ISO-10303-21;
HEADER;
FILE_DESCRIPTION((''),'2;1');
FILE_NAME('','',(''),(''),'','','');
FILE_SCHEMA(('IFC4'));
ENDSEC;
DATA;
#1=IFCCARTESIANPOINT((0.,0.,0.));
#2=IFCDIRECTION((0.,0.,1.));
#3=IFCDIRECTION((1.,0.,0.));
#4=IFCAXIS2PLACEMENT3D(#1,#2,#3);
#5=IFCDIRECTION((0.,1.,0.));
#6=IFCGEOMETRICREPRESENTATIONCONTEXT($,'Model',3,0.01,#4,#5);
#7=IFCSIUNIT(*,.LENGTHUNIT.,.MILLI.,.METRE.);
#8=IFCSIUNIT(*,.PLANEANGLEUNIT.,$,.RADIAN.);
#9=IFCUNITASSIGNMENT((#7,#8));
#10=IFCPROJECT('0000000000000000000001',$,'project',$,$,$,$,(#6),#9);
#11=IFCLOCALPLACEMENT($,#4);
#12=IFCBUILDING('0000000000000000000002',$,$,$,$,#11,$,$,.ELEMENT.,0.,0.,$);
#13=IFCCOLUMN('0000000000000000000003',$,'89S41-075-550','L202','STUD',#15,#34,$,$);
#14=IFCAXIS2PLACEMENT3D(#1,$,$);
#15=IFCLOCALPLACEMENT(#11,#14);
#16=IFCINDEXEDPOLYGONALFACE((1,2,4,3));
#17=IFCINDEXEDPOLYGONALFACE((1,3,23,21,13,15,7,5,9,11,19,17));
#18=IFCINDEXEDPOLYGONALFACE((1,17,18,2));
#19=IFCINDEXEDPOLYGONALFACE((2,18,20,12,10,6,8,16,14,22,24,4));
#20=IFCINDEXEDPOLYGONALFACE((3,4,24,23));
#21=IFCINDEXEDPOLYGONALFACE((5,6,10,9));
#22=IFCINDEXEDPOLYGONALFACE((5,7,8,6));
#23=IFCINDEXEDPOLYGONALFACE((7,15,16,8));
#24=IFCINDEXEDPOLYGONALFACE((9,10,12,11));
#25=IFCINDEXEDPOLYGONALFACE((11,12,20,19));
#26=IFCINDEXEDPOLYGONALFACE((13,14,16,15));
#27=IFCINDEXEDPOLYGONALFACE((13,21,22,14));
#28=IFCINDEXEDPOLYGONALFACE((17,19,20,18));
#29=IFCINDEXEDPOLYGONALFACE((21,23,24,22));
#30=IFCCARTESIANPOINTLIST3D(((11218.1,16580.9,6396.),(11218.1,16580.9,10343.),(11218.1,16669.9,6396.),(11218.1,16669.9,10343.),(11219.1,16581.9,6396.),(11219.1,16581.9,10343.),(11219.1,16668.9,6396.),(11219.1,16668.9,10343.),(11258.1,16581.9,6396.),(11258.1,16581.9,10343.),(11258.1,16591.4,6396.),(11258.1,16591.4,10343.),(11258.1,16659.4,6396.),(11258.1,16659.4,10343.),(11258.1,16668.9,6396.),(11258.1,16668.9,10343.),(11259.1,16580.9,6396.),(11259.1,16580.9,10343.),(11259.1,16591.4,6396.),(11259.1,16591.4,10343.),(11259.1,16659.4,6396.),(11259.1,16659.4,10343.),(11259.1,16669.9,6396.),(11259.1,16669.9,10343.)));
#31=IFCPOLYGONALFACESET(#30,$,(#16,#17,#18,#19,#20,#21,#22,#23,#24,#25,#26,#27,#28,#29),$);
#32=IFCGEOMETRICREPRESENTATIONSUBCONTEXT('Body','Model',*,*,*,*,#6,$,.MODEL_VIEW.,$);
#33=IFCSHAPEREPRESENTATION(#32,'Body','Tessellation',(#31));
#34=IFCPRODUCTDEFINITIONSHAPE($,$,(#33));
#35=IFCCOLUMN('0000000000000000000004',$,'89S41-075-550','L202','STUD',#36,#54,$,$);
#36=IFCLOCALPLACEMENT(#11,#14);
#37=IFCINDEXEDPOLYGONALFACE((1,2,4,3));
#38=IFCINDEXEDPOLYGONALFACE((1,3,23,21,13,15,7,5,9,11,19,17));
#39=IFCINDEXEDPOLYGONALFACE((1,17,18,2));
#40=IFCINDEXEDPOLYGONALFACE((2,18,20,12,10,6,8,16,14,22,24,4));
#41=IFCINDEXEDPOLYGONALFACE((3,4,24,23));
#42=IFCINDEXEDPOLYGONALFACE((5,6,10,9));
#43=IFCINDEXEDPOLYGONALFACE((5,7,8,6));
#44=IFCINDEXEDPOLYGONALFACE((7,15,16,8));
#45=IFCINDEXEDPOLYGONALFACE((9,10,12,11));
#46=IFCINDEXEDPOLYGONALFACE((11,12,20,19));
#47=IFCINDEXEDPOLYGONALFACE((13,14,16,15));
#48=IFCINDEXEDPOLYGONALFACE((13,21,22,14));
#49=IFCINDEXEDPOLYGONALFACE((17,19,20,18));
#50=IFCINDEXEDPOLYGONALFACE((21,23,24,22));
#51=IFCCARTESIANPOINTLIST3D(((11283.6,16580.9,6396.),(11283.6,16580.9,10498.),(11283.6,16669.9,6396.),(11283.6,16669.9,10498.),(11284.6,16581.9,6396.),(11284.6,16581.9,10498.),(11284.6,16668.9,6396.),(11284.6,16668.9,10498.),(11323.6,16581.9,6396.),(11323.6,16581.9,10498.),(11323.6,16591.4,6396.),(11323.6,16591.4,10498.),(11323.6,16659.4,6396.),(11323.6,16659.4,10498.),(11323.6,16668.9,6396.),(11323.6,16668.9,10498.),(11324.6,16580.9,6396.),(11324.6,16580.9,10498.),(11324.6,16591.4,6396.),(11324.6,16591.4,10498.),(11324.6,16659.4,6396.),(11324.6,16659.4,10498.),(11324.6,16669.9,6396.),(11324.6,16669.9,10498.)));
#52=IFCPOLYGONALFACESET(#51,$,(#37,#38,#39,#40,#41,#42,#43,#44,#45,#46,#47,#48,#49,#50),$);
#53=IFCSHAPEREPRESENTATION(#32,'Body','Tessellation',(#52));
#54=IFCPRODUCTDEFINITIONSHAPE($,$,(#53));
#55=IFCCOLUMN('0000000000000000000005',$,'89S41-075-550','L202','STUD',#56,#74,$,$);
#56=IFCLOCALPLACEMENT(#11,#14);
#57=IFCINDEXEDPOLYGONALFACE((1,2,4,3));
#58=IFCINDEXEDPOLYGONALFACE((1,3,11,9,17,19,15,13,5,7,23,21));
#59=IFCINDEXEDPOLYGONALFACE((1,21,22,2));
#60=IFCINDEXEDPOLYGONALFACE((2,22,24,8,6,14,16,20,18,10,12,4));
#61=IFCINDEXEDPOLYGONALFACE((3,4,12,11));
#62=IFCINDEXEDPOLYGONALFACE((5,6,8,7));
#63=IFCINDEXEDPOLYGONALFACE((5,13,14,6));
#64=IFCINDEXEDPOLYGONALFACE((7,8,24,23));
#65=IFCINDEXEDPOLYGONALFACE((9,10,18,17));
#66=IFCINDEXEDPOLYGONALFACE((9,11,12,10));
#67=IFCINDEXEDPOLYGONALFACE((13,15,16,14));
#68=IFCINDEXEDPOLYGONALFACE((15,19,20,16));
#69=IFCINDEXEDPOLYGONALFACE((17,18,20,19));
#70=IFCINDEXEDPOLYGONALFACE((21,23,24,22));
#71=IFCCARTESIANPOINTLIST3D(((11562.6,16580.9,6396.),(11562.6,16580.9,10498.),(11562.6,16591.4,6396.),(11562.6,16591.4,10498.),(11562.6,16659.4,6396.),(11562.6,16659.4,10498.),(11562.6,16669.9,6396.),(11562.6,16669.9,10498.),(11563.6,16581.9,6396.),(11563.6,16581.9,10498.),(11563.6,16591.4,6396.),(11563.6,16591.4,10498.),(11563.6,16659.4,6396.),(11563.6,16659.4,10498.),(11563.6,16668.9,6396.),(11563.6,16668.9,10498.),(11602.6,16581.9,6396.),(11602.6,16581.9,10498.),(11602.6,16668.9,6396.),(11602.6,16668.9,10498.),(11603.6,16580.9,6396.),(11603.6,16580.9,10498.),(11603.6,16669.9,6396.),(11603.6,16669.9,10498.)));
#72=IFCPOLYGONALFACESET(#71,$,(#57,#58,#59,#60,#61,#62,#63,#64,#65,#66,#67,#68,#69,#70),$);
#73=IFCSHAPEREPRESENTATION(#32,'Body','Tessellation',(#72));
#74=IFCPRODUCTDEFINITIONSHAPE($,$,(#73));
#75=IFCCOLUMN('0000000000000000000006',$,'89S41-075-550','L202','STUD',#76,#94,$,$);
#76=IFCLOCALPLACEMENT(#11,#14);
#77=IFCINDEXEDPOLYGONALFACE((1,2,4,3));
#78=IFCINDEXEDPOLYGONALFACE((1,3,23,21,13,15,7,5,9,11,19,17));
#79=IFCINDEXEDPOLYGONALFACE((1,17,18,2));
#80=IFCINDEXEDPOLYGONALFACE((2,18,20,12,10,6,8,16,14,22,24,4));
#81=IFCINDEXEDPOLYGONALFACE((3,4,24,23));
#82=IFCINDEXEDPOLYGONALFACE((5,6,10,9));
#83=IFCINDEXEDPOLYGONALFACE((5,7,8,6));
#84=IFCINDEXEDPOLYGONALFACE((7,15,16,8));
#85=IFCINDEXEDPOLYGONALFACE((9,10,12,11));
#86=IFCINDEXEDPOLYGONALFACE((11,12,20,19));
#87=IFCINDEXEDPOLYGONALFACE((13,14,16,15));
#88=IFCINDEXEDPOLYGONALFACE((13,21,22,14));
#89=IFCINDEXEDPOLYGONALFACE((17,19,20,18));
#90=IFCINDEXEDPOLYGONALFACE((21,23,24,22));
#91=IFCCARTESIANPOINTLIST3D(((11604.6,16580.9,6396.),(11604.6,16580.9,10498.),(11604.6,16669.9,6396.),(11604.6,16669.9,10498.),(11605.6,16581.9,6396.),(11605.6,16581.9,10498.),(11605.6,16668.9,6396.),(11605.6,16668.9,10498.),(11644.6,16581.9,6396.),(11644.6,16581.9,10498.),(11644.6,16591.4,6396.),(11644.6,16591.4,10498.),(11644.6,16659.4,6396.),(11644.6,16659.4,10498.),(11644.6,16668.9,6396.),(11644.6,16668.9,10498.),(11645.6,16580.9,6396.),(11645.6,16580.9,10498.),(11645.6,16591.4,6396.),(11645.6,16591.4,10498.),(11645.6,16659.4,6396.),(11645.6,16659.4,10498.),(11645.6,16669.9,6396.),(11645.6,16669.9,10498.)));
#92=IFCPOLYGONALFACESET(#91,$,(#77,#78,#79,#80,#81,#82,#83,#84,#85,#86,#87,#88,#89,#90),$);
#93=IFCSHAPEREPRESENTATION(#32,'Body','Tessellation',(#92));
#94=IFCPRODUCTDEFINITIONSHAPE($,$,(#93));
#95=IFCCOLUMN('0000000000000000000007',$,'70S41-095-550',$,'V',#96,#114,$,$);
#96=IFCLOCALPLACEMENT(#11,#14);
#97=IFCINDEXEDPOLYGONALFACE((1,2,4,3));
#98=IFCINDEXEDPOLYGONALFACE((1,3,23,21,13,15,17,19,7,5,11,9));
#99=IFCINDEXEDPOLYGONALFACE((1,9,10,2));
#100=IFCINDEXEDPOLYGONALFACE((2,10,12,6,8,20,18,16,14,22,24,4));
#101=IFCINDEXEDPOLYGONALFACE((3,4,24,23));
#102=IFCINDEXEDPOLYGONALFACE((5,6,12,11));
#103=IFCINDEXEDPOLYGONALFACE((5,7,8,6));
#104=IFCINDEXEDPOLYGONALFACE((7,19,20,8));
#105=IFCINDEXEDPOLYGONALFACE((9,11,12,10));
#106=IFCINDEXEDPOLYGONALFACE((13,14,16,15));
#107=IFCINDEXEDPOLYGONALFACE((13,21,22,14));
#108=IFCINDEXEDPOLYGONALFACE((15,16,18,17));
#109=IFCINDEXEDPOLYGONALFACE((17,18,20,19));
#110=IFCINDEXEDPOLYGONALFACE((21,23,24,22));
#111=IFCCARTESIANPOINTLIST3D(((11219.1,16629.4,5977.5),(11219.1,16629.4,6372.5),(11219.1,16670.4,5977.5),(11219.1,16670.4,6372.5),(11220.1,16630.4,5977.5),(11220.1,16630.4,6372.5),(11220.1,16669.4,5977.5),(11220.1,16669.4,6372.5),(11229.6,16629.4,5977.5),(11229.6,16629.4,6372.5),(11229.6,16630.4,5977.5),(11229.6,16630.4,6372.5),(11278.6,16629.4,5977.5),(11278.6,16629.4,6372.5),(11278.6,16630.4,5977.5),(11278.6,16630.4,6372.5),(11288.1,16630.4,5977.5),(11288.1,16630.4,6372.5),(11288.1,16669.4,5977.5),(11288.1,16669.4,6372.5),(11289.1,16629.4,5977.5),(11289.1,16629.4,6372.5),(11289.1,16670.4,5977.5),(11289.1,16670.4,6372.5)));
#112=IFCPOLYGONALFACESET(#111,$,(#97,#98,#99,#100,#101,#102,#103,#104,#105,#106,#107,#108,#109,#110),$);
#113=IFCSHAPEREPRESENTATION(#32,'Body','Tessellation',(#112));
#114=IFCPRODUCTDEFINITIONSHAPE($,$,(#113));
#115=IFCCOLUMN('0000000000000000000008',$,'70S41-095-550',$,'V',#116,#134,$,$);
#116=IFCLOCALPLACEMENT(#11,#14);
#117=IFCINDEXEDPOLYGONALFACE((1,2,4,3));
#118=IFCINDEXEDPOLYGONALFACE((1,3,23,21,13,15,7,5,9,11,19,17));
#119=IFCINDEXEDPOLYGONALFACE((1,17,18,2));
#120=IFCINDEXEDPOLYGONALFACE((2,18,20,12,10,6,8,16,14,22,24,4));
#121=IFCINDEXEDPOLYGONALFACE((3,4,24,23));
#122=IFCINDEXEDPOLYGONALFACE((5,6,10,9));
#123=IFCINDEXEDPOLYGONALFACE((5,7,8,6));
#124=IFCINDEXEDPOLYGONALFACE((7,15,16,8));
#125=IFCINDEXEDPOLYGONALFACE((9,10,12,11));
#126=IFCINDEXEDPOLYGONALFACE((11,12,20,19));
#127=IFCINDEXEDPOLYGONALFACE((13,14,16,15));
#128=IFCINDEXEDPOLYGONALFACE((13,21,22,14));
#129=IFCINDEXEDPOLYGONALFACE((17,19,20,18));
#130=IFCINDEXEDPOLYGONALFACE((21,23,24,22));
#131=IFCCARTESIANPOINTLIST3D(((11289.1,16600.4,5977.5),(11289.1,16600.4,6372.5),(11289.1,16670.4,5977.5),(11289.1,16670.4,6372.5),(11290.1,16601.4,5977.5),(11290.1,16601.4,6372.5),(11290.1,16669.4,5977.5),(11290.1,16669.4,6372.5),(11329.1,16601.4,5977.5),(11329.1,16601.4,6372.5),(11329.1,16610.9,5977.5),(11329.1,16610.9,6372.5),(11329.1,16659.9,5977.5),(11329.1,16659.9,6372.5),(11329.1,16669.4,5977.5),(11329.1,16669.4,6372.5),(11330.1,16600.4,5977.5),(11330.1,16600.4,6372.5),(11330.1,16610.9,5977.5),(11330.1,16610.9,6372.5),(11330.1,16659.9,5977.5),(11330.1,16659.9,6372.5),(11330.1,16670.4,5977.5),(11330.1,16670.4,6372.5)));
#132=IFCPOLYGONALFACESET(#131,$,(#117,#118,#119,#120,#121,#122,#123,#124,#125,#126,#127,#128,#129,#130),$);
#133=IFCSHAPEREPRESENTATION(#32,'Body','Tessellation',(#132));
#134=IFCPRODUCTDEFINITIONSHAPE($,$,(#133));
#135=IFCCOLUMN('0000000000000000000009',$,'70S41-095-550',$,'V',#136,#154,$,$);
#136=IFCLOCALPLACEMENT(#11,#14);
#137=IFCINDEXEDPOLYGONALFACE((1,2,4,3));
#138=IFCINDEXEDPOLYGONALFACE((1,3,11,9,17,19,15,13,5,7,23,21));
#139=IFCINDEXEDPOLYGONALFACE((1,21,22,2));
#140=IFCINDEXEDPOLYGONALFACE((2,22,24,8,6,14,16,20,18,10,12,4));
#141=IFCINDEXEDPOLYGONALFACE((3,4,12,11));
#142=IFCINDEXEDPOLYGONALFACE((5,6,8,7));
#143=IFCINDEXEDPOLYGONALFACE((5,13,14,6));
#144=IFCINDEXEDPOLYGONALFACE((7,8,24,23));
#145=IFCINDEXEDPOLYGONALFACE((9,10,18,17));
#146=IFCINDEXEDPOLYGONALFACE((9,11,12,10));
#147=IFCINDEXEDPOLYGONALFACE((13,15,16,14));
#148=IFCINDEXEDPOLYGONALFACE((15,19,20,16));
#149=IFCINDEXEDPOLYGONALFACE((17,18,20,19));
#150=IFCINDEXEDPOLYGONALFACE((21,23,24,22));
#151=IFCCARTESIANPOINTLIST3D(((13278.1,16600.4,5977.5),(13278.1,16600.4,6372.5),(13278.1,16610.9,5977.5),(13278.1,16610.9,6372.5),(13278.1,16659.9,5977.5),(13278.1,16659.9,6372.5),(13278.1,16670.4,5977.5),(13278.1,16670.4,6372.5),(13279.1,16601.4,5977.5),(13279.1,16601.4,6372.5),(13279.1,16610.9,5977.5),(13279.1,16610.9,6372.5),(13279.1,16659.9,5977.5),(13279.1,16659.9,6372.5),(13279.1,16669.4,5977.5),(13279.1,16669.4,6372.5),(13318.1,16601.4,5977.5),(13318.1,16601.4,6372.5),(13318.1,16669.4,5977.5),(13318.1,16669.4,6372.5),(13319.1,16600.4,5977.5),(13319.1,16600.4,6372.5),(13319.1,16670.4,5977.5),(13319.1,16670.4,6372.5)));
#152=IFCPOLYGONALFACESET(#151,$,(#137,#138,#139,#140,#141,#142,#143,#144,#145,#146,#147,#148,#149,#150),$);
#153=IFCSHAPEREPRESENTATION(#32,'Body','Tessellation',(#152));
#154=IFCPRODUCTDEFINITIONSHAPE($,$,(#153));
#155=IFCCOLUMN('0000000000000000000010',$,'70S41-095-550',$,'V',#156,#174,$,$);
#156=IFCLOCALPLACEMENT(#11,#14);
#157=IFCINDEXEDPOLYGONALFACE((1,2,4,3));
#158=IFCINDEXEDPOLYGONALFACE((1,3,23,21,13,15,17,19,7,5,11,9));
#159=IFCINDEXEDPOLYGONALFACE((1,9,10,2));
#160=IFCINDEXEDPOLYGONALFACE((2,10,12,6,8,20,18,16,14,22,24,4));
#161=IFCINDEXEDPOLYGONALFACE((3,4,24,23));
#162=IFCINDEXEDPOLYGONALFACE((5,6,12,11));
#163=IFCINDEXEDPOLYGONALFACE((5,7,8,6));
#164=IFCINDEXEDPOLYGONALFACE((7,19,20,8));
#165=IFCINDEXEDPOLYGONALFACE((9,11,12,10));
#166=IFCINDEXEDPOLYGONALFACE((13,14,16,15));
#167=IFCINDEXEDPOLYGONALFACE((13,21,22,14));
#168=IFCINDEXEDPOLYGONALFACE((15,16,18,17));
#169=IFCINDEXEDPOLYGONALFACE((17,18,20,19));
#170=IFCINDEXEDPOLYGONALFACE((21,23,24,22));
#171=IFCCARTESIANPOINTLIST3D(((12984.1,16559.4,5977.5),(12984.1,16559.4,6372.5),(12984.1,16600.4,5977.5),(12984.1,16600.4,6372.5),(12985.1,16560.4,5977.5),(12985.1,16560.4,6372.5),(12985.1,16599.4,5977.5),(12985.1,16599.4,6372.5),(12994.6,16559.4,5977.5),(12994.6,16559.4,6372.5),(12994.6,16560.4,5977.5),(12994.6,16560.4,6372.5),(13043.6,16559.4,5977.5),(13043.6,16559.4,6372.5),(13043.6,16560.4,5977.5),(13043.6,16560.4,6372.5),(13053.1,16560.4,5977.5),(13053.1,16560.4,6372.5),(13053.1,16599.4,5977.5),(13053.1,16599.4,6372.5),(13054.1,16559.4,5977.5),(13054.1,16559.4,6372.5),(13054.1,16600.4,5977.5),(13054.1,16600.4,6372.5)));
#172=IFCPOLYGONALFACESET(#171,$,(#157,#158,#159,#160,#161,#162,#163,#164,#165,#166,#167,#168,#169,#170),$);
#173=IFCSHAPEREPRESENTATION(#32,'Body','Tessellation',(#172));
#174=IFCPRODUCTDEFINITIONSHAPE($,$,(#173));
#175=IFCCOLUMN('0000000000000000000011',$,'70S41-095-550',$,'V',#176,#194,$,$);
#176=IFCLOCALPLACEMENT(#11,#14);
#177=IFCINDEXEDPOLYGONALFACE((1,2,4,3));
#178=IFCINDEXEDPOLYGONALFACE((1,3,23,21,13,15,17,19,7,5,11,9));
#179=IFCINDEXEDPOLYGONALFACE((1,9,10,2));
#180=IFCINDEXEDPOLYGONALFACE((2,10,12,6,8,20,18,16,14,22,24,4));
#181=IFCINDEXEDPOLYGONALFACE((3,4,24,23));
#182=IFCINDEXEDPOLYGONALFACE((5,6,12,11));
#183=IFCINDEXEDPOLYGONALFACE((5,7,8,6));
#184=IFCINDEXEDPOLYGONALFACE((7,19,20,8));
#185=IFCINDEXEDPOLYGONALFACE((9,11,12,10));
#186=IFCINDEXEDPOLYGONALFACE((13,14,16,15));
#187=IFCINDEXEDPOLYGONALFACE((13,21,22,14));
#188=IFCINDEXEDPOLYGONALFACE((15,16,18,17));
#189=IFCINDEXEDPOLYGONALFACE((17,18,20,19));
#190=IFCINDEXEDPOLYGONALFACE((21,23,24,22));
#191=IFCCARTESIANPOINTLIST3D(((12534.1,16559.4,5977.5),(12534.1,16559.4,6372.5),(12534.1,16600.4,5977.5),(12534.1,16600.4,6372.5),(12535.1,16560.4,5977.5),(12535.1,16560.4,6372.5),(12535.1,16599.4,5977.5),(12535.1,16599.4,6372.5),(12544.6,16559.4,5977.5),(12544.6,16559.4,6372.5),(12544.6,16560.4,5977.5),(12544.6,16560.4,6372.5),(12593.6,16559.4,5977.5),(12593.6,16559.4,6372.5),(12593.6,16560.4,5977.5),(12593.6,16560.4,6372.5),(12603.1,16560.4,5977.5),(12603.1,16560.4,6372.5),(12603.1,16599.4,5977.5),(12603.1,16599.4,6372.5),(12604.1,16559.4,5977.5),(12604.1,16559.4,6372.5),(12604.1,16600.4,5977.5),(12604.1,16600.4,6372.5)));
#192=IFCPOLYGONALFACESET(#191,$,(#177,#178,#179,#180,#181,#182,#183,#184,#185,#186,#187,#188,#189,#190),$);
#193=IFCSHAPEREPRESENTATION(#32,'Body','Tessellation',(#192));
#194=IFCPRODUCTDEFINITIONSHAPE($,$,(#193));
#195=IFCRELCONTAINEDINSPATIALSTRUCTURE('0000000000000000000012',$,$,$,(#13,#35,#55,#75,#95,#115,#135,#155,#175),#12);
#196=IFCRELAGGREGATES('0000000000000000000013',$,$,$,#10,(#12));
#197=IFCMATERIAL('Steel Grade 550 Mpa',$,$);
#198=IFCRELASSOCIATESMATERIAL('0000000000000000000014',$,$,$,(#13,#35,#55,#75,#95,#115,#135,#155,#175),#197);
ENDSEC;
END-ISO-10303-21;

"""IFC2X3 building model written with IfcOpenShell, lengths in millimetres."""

from ifc_helpers import new_model, si_unit, direction, frame, origin, origin_with_axes, origin_2d_with_axis, place, context, subcontext, project, spatial, c_section, extrude, source, transform, mapped, material, element, save


model = new_model("IFC2X3")

# Units and contexts
model_context = context("Model", 3, precision=0.01, world=origin_with_axes(), true_north=direction((0.0, 1.0, 0.0)))
body_context = subcontext(model_context, "Body", "Model", "MODEL_VIEW")
ifc_project = project(units=[si_unit("LENGTHUNIT", "METRE", prefix="MILLI"), si_unit("PLANEANGLEUNIT", "RADIAN")], contexts=[model_context])

# Building
building_placement = place(None, origin_with_axes())
building = spatial("IfcBuilding", under=ifc_project, at=building_placement, CompositionType="ELEMENT", ElevationOfRefHeight=0.0, ElevationOfTerrain=0.0)

# Columns
ifc_material = material(Name="Steel Grade 550 Mpa")
shared_shape_1 = source(origin(), body_context, "Body", "SweptSolid", [
    extrude(c_section(Depth=89.0, Width=41.0, WallThickness=1.0, Girth=10.5, at=origin_2d_with_axis()), origin_with_axes(), (0.0, 0.0, 1.0), 3947.0),
])
column_1_placement = place(None, frame((11238.6, 16625.4, 6396.0), z_axis=(0.0, 0.0, 1.0), x_axis=(1.0, 0.0, 0.0)))
element("IfcColumn", 1, at=column_1_placement, inside=building, material=ifc_material, Name="89S41-075-550", Description="L202", ObjectType="STUD", context=body_context, shape_type="MappedRepresentation", body=[
    mapped(shared_shape_1, transform((0.0, 0.0, 0.0), scale=1.0)),
])
shared_shape_2 = source(origin(), body_context, "Body", "SweptSolid", [
    extrude(c_section(Depth=89.0, Width=41.0, WallThickness=1.0, Girth=10.5, at=origin_2d_with_axis()), origin_with_axes(), (0.0, 0.0, 1.0), 4102.0),
])
column_2_placement = place(None, frame((11304.1, 16625.4, 6396.0), z_axis=(0.0, 0.0, 1.0), x_axis=(1.0, 0.0, 0.0)))
element("IfcColumn", 2, at=column_2_placement, inside=building, material=ifc_material, Name="89S41-075-550", Description="L202", ObjectType="STUD", context=body_context, shape_type="MappedRepresentation", body=[
    mapped(shared_shape_2, transform((0.0, 0.0, 0.0), scale=1.0)),
])
shared_shape_3 = source(origin(), body_context, "Body", "SweptSolid", [
    extrude(c_section(Depth=89.0, Width=41.0, WallThickness=1.0, Girth=10.5, at=origin_2d_with_axis()), origin_with_axes(), (0.0, 0.0, 1.0), 4102.0),
])
column_3_placement = place(None, frame((11583.1, 16625.4, 6396.0), z_axis=(0.0, 0.0, 1.0), x_axis=(-1.0, 0.0, 0.0)))
element("IfcColumn", 3, at=column_3_placement, inside=building, material=ifc_material, Name="89S41-075-550", Description="L202", ObjectType="STUD", context=body_context, shape_type="MappedRepresentation", body=[
    mapped(shared_shape_3, transform((0.0, 0.0, 0.0), scale=1.0)),
])
shared_shape_4 = source(origin(), body_context, "Body", "SweptSolid", [
    extrude(c_section(Depth=89.0, Width=41.0, WallThickness=1.0, Girth=10.5, at=origin_2d_with_axis()), origin_with_axes(), (0.0, 0.0, 1.0), 4102.0),
])
column_4_placement = place(None, frame((11625.1, 16625.4, 6396.0), z_axis=(0.0, 0.0, 1.0), x_axis=(1.0, 0.0, 0.0)))
element("IfcColumn", 4, at=column_4_placement, inside=building, material=ifc_material, Name="89S41-075-550", Description="L202", ObjectType="STUD", context=body_context, shape_type="MappedRepresentation", body=[
    mapped(shared_shape_4, transform((0.0, 0.0, 0.0), scale=1.0)),
])
shared_shape_5 = source(origin(), body_context, "Body", "SweptSolid", [
    extrude(c_section(Depth=70.0, Width=41.0, WallThickness=1.0, Girth=10.5, at=origin_2d_with_axis()), origin_with_axes(), (0.0, 0.0, 1.0), 395.0),
])
column_5_placement = place(None, frame((11254.1, 16649.9, 5977.5), z_axis=(0.0, 0.0, 1.0), x_axis=(0.0, -1.0, 0.0)))
element("IfcColumn", 5, at=column_5_placement, inside=building, material=ifc_material, Name="70S41-095-550", ObjectType="V", context=body_context, shape_type="MappedRepresentation", body=[
    mapped(shared_shape_5, transform((0.0, 0.0, 0.0), scale=1.0)),
])
shared_shape_6 = source(origin(), body_context, "Body", "SweptSolid", [
    extrude(c_section(Depth=70.0, Width=41.0, WallThickness=1.0, Girth=10.5, at=origin_2d_with_axis()), origin_with_axes(), (0.0, 0.0, 1.0), 395.0),
])
column_6_placement = place(None, frame((11309.6, 16635.4, 5977.5), z_axis=(0.0, 0.0, 1.0), x_axis=(1.0, 0.0, 0.0)))
element("IfcColumn", 6, at=column_6_placement, inside=building, material=ifc_material, Name="70S41-095-550", ObjectType="V", context=body_context, shape_type="MappedRepresentation", body=[
    mapped(shared_shape_6, transform((0.0, 0.0, 0.0), scale=1.0)),
])
shared_shape_7 = source(origin(), body_context, "Body", "SweptSolid", [
    extrude(c_section(Depth=70.0, Width=41.0, WallThickness=1.0, Girth=10.5, at=origin_2d_with_axis()), origin_with_axes(), (0.0, 0.0, 1.0), 395.0),
])
column_7_placement = place(None, frame((13298.6, 16635.4, 6372.5), z_axis=(0.0, 0.0, -1.0), x_axis=(-1.0, 0.0, 0.0)))
element("IfcColumn", 7, at=column_7_placement, inside=building, material=ifc_material, Name="70S41-095-550", ObjectType="V", context=body_context, shape_type="MappedRepresentation", body=[
    mapped(shared_shape_7, transform((0.0, 0.0, 0.0), scale=1.0)),
])
shared_shape_8 = source(origin(), body_context, "Body", "SweptSolid", [
    extrude(c_section(Depth=70.0, Width=41.0, WallThickness=1.0, Girth=10.5, at=origin_2d_with_axis()), origin_with_axes(), (0.0, 0.0, 1.0), 395.0),
])
column_8_placement = place(None, frame((13019.1, 16579.9, 5977.5), z_axis=(0.0, 0.0, 1.0), x_axis=(0.0, -1.0, 0.0)))
element("IfcColumn", 8, at=column_8_placement, inside=building, material=ifc_material, Name="70S41-095-550", ObjectType="V", context=body_context, shape_type="MappedRepresentation", body=[
    mapped(shared_shape_8, transform((0.0, 0.0, 0.0), scale=1.0)),
])
shared_shape_9 = source(origin(), body_context, "Body", "SweptSolid", [
    extrude(c_section(Depth=70.0, Width=41.0, WallThickness=1.0, Girth=10.5, at=origin_2d_with_axis()), origin_with_axes(), (0.0, 0.0, 1.0), 395.0),
])
column_9_placement = place(None, frame((12569.1, 16579.9, 5977.5), z_axis=(0.0, 0.0, 1.0), x_axis=(0.0, -1.0, 0.0)))
element("IfcColumn", 9, at=column_9_placement, inside=building, material=ifc_material, Name="70S41-095-550", ObjectType="V", context=body_context, shape_type="MappedRepresentation", body=[
    mapped(shared_shape_9, transform((0.0, 0.0, 0.0), scale=1.0)),
])

save(model, "model.ifc")
